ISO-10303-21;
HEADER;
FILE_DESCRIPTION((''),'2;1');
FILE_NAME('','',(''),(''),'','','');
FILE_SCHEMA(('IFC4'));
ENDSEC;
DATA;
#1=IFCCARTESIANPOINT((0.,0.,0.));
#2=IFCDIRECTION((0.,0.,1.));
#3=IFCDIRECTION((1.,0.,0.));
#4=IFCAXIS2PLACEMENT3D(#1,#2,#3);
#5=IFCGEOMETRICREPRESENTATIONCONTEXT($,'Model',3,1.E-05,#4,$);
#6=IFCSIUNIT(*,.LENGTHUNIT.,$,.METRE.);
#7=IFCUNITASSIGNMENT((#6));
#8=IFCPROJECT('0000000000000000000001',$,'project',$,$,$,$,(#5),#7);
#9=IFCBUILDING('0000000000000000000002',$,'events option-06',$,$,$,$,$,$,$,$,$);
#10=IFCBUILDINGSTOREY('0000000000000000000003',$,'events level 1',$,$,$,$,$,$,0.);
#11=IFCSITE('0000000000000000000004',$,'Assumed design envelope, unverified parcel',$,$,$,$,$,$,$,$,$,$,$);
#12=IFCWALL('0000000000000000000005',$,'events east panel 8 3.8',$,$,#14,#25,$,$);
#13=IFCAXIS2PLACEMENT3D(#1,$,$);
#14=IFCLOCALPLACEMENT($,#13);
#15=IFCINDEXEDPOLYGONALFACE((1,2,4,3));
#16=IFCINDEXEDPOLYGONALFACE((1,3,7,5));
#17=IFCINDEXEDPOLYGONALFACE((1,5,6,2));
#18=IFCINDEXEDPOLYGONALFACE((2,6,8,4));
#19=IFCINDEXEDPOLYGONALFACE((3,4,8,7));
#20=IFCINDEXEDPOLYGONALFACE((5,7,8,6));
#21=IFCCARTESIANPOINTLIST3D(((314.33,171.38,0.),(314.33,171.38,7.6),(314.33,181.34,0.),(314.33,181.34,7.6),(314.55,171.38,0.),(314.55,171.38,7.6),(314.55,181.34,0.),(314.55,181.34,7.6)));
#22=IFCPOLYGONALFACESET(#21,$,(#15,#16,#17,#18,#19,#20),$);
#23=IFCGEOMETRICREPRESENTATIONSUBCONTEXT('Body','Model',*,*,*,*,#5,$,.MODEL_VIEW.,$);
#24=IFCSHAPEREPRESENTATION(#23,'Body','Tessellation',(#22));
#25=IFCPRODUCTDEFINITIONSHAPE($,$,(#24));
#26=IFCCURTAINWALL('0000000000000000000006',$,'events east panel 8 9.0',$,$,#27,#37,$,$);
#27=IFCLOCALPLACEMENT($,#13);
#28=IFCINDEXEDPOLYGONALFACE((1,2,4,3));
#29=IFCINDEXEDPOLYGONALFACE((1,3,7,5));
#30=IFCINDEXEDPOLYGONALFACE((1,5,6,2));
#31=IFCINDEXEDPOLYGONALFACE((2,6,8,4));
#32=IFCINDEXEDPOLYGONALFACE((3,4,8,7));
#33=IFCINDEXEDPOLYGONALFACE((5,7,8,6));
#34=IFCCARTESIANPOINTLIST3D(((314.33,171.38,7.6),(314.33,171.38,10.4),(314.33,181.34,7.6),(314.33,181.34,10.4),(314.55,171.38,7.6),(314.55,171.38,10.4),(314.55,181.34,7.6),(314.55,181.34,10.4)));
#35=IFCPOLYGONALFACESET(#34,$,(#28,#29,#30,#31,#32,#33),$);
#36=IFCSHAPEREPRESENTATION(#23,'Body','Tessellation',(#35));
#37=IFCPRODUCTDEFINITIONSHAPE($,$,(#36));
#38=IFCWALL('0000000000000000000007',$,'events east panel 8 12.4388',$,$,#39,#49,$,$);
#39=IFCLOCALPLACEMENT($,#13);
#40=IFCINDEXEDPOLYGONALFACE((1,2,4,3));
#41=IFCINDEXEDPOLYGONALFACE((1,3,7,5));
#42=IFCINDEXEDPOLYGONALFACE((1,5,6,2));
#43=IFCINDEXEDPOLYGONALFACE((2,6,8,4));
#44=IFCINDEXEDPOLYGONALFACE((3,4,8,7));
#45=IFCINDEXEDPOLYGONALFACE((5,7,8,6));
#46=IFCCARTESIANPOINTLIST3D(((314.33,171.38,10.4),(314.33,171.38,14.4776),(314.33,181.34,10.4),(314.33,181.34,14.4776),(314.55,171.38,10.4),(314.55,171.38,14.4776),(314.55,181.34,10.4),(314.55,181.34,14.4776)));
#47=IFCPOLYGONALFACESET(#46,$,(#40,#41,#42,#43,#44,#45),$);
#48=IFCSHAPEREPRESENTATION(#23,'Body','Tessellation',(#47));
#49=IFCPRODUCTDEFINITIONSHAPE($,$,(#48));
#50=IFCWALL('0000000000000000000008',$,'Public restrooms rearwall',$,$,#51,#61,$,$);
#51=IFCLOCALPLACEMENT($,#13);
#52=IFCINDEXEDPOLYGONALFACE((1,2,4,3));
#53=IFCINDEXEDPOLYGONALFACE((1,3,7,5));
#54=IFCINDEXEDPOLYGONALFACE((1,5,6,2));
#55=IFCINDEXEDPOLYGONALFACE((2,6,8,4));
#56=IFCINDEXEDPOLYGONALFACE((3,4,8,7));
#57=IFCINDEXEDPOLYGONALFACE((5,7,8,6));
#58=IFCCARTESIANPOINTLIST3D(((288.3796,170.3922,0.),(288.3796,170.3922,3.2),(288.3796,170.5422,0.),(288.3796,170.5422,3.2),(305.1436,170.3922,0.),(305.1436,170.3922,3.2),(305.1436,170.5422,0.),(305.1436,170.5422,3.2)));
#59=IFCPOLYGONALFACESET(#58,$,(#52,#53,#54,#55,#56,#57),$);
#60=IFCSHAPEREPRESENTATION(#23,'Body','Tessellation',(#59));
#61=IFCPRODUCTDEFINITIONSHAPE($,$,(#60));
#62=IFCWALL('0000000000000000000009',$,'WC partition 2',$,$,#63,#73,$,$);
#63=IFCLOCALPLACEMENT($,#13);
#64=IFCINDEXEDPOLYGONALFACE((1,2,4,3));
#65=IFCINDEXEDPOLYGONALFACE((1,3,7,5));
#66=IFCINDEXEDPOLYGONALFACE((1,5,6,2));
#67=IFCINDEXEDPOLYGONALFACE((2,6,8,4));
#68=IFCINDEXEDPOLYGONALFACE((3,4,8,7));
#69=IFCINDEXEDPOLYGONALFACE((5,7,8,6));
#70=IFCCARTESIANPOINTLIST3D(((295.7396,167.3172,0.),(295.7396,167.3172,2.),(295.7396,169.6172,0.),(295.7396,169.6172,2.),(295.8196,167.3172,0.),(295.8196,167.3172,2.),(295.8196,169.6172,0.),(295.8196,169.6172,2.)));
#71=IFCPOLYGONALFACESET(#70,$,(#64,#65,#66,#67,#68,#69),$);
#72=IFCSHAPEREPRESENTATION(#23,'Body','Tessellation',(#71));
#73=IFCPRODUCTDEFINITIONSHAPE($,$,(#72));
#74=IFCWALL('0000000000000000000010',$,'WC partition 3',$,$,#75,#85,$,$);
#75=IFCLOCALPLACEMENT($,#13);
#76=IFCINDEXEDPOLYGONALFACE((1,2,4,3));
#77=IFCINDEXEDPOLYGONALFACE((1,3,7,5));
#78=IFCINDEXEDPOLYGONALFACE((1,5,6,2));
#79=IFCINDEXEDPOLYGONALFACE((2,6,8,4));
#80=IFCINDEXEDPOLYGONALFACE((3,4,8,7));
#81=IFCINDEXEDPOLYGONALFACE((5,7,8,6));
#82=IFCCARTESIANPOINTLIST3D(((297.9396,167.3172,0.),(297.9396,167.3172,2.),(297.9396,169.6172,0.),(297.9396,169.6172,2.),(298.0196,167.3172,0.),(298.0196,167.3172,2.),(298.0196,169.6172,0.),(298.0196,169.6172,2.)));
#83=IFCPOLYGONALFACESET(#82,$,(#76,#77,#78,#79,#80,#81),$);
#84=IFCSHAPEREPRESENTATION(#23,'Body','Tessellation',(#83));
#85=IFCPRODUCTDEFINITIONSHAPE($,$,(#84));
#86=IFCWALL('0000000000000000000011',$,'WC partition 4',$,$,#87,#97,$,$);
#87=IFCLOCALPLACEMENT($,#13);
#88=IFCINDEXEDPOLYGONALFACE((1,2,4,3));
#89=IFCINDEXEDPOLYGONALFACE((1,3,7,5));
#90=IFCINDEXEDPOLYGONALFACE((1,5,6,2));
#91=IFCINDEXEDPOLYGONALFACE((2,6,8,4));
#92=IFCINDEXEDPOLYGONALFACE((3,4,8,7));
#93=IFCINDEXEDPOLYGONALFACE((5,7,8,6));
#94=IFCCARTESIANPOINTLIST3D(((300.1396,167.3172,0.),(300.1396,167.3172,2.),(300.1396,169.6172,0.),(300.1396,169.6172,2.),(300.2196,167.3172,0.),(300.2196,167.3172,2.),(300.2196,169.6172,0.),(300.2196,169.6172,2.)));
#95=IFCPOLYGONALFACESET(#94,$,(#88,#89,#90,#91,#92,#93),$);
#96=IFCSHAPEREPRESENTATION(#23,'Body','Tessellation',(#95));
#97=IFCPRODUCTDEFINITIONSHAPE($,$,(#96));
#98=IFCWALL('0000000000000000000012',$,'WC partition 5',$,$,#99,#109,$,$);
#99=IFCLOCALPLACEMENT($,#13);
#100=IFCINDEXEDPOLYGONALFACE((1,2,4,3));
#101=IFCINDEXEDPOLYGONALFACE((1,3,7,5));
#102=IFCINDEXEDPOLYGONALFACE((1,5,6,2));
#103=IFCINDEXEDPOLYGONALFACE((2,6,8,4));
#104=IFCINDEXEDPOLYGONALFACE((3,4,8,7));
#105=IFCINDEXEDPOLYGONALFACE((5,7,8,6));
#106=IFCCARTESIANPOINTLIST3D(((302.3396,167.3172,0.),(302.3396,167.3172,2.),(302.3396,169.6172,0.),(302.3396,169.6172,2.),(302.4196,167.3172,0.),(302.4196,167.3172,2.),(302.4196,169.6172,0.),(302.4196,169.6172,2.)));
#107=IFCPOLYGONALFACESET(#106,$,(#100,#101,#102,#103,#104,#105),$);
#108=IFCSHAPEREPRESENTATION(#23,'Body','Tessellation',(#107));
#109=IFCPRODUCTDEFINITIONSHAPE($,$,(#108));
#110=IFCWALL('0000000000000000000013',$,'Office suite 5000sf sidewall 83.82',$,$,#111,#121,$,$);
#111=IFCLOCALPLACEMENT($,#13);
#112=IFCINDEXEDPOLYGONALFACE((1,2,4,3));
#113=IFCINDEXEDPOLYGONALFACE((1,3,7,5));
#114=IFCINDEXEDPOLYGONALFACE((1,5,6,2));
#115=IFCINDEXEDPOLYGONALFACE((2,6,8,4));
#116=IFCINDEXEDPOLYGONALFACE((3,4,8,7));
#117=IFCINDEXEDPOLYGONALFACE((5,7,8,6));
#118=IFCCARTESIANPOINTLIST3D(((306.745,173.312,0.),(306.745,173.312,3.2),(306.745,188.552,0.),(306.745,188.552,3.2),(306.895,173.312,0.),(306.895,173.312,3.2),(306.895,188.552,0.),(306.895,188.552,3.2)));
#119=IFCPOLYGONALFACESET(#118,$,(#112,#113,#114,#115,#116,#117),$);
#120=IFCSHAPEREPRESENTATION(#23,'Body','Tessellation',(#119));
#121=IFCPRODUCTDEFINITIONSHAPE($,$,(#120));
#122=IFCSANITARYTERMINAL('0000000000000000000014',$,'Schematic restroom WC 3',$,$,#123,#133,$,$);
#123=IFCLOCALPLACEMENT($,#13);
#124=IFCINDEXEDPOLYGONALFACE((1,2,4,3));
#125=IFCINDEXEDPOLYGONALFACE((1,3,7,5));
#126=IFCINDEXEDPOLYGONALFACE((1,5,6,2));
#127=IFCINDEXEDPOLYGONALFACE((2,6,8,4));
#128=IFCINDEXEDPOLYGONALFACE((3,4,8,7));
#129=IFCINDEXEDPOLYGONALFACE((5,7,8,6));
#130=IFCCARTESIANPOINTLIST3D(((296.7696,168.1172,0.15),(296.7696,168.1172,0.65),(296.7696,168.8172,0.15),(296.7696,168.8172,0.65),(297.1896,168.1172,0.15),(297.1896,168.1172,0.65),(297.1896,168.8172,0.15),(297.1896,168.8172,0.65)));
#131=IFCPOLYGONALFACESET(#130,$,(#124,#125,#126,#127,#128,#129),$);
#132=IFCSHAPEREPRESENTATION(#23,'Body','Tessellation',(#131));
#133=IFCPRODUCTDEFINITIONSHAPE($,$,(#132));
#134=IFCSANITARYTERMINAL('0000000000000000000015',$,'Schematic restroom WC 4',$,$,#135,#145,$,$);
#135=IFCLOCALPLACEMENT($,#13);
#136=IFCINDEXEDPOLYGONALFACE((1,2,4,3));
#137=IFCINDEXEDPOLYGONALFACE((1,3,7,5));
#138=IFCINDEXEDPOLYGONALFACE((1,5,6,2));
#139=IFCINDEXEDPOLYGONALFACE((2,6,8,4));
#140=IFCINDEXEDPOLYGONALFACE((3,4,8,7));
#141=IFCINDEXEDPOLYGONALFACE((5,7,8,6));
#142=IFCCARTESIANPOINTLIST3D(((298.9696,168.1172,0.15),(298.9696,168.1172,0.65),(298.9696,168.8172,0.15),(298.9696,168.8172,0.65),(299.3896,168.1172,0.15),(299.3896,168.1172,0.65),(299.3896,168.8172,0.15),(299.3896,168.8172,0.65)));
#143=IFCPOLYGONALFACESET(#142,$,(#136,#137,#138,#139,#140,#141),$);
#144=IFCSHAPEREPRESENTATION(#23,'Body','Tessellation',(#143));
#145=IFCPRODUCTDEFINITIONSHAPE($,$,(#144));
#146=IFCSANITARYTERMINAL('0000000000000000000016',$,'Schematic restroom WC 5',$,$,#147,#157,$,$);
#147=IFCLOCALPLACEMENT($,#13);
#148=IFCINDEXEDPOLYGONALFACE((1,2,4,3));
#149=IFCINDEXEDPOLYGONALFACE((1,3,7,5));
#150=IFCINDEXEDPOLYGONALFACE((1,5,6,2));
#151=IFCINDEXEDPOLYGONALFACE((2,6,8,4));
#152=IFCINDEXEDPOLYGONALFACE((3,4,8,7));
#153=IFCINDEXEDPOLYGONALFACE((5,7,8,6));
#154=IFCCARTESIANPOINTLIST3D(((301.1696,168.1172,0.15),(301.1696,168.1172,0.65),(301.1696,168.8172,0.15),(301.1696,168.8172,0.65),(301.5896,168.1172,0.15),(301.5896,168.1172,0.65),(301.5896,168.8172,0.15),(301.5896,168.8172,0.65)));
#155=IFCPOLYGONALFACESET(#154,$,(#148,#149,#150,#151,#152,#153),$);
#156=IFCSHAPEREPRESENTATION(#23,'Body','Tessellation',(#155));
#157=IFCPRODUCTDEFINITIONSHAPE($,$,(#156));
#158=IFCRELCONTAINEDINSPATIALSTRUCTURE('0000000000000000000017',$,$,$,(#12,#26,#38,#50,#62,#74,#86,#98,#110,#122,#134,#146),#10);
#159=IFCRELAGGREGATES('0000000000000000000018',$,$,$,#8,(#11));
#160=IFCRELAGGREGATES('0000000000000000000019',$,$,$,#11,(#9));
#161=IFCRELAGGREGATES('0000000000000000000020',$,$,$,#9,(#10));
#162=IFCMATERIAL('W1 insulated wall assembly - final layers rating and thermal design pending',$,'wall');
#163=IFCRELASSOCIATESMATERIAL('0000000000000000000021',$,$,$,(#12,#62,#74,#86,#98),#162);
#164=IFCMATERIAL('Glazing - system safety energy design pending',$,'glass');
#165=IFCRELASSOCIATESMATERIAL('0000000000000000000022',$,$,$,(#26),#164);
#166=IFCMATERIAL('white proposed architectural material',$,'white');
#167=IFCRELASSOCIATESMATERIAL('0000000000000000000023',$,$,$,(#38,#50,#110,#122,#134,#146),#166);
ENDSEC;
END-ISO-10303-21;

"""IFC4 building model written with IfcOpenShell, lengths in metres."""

from ifc_helpers import new_model, si_unit, frame, origin_with_axes, place, context, subcontext, project, spatial, rectangle, extrude, material, element, save


model = new_model("IFC4")

# Units and contexts
model_context = context("Model", 3, precision=1e-05, world=origin_with_axes())
body_context = subcontext(model_context, "Body", "Model", "MODEL_VIEW")
ifc_project = project(units=[si_unit("LENGTHUNIT", "METRE")], contexts=[model_context])

# Site, building, storey
site = spatial("IfcSite", under=ifc_project, Name="Assumed design envelope, unverified parcel")
building = spatial("IfcBuilding", under=site, Name="events option-06")
storey = spatial("IfcBuildingStorey", under=building, Name="events level 1", Elevation=0.0)

# Shared definitions
ifc_material_1 = material(Name="W1 insulated wall assembly - final layers rating and thermal design pending", Category="wall")
ifc_material_2 = material(Name="Glazing - system safety energy design pending", Category="glass")

# Wall
wall_1_placement = place(None, frame((314.44, 176.36, 0.0), z_axis=(0.0, 0.0, 1.0), x_axis=(1.0, 0.0, 0.0)))
element("IfcWall", 1, at=wall_1_placement, inside=storey, material=ifc_material_1, Name="events east panel 8 3.8", context=body_context, shape_type="SweptSolid", body=[
    extrude(rectangle(XDim=0.22, YDim=9.96), origin_with_axes(), (0.0, 0.0, 1.0), 7.6),
])

# Curtain wall
curtain_wall_placement = place(None, frame((314.44, 176.36, 7.6), z_axis=(0.0, 0.0, 1.0), x_axis=(1.0, 0.0, 0.0)))
element("IfcCurtainWall", 2, at=curtain_wall_placement, inside=storey, material=ifc_material_2, Name="events east panel 8 9.0", context=body_context, shape_type="SweptSolid", body=[
    extrude(rectangle(XDim=0.22, YDim=9.96), origin_with_axes(), (0.0, 0.0, 1.0), 2.8),
])

# Walls
ifc_material_3 = material(Name="white proposed architectural material", Category="white")
wall_2_placement = place(None, frame((314.44, 176.36, 10.4), z_axis=(0.0, 0.0, 1.0), x_axis=(1.0, 0.0, 0.0)))
element("IfcWall", 3, at=wall_2_placement, inside=storey, material=ifc_material_3, Name="events east panel 8 12.4388", context=body_context, shape_type="SweptSolid", body=[
    extrude(rectangle(XDim=0.22, YDim=9.96), origin_with_axes(), (0.0, 0.0, 1.0), 4.0776),
])
wall_3_placement = place(None, frame((296.7616, 170.4672, 0.0), z_axis=(0.0, 0.0, 1.0), x_axis=(1.0, 0.0, 0.0)))
element("IfcWall", 4, at=wall_3_placement, inside=storey, material=ifc_material_3, Name="Public restrooms rearwall", context=body_context, shape_type="SweptSolid", body=[
    extrude(rectangle(XDim=16.764, YDim=0.15), origin_with_axes(), (0.0, 0.0, 1.0), 3.2),
])
for number, where, z_axis, x_axis, name in (
    (5, (295.7796, 168.4672, 0.0), (0.0, 0.0, 1.0), (1.0, 0.0, 0.0), "WC partition 2"),
    (6, (297.9796, 168.4672, 0.0), (0.0, 0.0, 1.0), (1.0, 0.0, 0.0), "WC partition 3"),
    (7, (300.1796, 168.4672, 0.0), (0.0, 0.0, 1.0), (1.0, 0.0, 0.0), "WC partition 4"),
    (8, (302.3796, 168.4672, 0.0), (0.0, 0.0, 1.0), (1.0, 0.0, 0.0), "WC partition 5"),
):
    element("IfcWall", number, at=place(None, frame(where, z_axis=z_axis, x_axis=x_axis)), inside=storey, material=ifc_material_1, Name=name, context=body_context, shape_type="SweptSolid", body=[
        extrude(rectangle(XDim=0.08, YDim=2.3), origin_with_axes(), (0.0, 0.0, 1.0), 2.0),
    ])
wall_4_placement = place(None, frame((306.82, 180.932, 0.0), z_axis=(0.0, 0.0, 1.0), x_axis=(1.0, 0.0, 0.0)))
element("IfcWall", 9, at=wall_4_placement, inside=storey, material=ifc_material_3, Name="Office suite 5000sf sidewall 83.82", context=body_context, shape_type="SweptSolid", body=[
    extrude(rectangle(XDim=0.15, YDim=15.24), origin_with_axes(), (0.0, 0.0, 1.0), 3.2),
])

# Sanitary terminals
for number, where, z_axis, x_axis, name in (
    (10, (296.9796, 168.4672, 0.15), (0.0, 0.0, 1.0), (1.0, 0.0, 0.0), "Schematic restroom WC 3"),
    (11, (299.1796, 168.4672, 0.15), (0.0, 0.0, 1.0), (1.0, 0.0, 0.0), "Schematic restroom WC 4"),
    (12, (301.3796, 168.4672, 0.15), (0.0, 0.0, 1.0), (1.0, 0.0, 0.0), "Schematic restroom WC 5"),
):
    element("IfcSanitaryTerminal", number, at=place(None, frame(where, z_axis=z_axis, x_axis=x_axis)), inside=storey, material=ifc_material_3, Name=name, context=body_context, shape_type="SweptSolid", body=[
        extrude(rectangle(XDim=0.42, YDim=0.7), origin_with_axes(), (0.0, 0.0, 1.0), 0.5),
    ])

save(model, "model.ifc")
